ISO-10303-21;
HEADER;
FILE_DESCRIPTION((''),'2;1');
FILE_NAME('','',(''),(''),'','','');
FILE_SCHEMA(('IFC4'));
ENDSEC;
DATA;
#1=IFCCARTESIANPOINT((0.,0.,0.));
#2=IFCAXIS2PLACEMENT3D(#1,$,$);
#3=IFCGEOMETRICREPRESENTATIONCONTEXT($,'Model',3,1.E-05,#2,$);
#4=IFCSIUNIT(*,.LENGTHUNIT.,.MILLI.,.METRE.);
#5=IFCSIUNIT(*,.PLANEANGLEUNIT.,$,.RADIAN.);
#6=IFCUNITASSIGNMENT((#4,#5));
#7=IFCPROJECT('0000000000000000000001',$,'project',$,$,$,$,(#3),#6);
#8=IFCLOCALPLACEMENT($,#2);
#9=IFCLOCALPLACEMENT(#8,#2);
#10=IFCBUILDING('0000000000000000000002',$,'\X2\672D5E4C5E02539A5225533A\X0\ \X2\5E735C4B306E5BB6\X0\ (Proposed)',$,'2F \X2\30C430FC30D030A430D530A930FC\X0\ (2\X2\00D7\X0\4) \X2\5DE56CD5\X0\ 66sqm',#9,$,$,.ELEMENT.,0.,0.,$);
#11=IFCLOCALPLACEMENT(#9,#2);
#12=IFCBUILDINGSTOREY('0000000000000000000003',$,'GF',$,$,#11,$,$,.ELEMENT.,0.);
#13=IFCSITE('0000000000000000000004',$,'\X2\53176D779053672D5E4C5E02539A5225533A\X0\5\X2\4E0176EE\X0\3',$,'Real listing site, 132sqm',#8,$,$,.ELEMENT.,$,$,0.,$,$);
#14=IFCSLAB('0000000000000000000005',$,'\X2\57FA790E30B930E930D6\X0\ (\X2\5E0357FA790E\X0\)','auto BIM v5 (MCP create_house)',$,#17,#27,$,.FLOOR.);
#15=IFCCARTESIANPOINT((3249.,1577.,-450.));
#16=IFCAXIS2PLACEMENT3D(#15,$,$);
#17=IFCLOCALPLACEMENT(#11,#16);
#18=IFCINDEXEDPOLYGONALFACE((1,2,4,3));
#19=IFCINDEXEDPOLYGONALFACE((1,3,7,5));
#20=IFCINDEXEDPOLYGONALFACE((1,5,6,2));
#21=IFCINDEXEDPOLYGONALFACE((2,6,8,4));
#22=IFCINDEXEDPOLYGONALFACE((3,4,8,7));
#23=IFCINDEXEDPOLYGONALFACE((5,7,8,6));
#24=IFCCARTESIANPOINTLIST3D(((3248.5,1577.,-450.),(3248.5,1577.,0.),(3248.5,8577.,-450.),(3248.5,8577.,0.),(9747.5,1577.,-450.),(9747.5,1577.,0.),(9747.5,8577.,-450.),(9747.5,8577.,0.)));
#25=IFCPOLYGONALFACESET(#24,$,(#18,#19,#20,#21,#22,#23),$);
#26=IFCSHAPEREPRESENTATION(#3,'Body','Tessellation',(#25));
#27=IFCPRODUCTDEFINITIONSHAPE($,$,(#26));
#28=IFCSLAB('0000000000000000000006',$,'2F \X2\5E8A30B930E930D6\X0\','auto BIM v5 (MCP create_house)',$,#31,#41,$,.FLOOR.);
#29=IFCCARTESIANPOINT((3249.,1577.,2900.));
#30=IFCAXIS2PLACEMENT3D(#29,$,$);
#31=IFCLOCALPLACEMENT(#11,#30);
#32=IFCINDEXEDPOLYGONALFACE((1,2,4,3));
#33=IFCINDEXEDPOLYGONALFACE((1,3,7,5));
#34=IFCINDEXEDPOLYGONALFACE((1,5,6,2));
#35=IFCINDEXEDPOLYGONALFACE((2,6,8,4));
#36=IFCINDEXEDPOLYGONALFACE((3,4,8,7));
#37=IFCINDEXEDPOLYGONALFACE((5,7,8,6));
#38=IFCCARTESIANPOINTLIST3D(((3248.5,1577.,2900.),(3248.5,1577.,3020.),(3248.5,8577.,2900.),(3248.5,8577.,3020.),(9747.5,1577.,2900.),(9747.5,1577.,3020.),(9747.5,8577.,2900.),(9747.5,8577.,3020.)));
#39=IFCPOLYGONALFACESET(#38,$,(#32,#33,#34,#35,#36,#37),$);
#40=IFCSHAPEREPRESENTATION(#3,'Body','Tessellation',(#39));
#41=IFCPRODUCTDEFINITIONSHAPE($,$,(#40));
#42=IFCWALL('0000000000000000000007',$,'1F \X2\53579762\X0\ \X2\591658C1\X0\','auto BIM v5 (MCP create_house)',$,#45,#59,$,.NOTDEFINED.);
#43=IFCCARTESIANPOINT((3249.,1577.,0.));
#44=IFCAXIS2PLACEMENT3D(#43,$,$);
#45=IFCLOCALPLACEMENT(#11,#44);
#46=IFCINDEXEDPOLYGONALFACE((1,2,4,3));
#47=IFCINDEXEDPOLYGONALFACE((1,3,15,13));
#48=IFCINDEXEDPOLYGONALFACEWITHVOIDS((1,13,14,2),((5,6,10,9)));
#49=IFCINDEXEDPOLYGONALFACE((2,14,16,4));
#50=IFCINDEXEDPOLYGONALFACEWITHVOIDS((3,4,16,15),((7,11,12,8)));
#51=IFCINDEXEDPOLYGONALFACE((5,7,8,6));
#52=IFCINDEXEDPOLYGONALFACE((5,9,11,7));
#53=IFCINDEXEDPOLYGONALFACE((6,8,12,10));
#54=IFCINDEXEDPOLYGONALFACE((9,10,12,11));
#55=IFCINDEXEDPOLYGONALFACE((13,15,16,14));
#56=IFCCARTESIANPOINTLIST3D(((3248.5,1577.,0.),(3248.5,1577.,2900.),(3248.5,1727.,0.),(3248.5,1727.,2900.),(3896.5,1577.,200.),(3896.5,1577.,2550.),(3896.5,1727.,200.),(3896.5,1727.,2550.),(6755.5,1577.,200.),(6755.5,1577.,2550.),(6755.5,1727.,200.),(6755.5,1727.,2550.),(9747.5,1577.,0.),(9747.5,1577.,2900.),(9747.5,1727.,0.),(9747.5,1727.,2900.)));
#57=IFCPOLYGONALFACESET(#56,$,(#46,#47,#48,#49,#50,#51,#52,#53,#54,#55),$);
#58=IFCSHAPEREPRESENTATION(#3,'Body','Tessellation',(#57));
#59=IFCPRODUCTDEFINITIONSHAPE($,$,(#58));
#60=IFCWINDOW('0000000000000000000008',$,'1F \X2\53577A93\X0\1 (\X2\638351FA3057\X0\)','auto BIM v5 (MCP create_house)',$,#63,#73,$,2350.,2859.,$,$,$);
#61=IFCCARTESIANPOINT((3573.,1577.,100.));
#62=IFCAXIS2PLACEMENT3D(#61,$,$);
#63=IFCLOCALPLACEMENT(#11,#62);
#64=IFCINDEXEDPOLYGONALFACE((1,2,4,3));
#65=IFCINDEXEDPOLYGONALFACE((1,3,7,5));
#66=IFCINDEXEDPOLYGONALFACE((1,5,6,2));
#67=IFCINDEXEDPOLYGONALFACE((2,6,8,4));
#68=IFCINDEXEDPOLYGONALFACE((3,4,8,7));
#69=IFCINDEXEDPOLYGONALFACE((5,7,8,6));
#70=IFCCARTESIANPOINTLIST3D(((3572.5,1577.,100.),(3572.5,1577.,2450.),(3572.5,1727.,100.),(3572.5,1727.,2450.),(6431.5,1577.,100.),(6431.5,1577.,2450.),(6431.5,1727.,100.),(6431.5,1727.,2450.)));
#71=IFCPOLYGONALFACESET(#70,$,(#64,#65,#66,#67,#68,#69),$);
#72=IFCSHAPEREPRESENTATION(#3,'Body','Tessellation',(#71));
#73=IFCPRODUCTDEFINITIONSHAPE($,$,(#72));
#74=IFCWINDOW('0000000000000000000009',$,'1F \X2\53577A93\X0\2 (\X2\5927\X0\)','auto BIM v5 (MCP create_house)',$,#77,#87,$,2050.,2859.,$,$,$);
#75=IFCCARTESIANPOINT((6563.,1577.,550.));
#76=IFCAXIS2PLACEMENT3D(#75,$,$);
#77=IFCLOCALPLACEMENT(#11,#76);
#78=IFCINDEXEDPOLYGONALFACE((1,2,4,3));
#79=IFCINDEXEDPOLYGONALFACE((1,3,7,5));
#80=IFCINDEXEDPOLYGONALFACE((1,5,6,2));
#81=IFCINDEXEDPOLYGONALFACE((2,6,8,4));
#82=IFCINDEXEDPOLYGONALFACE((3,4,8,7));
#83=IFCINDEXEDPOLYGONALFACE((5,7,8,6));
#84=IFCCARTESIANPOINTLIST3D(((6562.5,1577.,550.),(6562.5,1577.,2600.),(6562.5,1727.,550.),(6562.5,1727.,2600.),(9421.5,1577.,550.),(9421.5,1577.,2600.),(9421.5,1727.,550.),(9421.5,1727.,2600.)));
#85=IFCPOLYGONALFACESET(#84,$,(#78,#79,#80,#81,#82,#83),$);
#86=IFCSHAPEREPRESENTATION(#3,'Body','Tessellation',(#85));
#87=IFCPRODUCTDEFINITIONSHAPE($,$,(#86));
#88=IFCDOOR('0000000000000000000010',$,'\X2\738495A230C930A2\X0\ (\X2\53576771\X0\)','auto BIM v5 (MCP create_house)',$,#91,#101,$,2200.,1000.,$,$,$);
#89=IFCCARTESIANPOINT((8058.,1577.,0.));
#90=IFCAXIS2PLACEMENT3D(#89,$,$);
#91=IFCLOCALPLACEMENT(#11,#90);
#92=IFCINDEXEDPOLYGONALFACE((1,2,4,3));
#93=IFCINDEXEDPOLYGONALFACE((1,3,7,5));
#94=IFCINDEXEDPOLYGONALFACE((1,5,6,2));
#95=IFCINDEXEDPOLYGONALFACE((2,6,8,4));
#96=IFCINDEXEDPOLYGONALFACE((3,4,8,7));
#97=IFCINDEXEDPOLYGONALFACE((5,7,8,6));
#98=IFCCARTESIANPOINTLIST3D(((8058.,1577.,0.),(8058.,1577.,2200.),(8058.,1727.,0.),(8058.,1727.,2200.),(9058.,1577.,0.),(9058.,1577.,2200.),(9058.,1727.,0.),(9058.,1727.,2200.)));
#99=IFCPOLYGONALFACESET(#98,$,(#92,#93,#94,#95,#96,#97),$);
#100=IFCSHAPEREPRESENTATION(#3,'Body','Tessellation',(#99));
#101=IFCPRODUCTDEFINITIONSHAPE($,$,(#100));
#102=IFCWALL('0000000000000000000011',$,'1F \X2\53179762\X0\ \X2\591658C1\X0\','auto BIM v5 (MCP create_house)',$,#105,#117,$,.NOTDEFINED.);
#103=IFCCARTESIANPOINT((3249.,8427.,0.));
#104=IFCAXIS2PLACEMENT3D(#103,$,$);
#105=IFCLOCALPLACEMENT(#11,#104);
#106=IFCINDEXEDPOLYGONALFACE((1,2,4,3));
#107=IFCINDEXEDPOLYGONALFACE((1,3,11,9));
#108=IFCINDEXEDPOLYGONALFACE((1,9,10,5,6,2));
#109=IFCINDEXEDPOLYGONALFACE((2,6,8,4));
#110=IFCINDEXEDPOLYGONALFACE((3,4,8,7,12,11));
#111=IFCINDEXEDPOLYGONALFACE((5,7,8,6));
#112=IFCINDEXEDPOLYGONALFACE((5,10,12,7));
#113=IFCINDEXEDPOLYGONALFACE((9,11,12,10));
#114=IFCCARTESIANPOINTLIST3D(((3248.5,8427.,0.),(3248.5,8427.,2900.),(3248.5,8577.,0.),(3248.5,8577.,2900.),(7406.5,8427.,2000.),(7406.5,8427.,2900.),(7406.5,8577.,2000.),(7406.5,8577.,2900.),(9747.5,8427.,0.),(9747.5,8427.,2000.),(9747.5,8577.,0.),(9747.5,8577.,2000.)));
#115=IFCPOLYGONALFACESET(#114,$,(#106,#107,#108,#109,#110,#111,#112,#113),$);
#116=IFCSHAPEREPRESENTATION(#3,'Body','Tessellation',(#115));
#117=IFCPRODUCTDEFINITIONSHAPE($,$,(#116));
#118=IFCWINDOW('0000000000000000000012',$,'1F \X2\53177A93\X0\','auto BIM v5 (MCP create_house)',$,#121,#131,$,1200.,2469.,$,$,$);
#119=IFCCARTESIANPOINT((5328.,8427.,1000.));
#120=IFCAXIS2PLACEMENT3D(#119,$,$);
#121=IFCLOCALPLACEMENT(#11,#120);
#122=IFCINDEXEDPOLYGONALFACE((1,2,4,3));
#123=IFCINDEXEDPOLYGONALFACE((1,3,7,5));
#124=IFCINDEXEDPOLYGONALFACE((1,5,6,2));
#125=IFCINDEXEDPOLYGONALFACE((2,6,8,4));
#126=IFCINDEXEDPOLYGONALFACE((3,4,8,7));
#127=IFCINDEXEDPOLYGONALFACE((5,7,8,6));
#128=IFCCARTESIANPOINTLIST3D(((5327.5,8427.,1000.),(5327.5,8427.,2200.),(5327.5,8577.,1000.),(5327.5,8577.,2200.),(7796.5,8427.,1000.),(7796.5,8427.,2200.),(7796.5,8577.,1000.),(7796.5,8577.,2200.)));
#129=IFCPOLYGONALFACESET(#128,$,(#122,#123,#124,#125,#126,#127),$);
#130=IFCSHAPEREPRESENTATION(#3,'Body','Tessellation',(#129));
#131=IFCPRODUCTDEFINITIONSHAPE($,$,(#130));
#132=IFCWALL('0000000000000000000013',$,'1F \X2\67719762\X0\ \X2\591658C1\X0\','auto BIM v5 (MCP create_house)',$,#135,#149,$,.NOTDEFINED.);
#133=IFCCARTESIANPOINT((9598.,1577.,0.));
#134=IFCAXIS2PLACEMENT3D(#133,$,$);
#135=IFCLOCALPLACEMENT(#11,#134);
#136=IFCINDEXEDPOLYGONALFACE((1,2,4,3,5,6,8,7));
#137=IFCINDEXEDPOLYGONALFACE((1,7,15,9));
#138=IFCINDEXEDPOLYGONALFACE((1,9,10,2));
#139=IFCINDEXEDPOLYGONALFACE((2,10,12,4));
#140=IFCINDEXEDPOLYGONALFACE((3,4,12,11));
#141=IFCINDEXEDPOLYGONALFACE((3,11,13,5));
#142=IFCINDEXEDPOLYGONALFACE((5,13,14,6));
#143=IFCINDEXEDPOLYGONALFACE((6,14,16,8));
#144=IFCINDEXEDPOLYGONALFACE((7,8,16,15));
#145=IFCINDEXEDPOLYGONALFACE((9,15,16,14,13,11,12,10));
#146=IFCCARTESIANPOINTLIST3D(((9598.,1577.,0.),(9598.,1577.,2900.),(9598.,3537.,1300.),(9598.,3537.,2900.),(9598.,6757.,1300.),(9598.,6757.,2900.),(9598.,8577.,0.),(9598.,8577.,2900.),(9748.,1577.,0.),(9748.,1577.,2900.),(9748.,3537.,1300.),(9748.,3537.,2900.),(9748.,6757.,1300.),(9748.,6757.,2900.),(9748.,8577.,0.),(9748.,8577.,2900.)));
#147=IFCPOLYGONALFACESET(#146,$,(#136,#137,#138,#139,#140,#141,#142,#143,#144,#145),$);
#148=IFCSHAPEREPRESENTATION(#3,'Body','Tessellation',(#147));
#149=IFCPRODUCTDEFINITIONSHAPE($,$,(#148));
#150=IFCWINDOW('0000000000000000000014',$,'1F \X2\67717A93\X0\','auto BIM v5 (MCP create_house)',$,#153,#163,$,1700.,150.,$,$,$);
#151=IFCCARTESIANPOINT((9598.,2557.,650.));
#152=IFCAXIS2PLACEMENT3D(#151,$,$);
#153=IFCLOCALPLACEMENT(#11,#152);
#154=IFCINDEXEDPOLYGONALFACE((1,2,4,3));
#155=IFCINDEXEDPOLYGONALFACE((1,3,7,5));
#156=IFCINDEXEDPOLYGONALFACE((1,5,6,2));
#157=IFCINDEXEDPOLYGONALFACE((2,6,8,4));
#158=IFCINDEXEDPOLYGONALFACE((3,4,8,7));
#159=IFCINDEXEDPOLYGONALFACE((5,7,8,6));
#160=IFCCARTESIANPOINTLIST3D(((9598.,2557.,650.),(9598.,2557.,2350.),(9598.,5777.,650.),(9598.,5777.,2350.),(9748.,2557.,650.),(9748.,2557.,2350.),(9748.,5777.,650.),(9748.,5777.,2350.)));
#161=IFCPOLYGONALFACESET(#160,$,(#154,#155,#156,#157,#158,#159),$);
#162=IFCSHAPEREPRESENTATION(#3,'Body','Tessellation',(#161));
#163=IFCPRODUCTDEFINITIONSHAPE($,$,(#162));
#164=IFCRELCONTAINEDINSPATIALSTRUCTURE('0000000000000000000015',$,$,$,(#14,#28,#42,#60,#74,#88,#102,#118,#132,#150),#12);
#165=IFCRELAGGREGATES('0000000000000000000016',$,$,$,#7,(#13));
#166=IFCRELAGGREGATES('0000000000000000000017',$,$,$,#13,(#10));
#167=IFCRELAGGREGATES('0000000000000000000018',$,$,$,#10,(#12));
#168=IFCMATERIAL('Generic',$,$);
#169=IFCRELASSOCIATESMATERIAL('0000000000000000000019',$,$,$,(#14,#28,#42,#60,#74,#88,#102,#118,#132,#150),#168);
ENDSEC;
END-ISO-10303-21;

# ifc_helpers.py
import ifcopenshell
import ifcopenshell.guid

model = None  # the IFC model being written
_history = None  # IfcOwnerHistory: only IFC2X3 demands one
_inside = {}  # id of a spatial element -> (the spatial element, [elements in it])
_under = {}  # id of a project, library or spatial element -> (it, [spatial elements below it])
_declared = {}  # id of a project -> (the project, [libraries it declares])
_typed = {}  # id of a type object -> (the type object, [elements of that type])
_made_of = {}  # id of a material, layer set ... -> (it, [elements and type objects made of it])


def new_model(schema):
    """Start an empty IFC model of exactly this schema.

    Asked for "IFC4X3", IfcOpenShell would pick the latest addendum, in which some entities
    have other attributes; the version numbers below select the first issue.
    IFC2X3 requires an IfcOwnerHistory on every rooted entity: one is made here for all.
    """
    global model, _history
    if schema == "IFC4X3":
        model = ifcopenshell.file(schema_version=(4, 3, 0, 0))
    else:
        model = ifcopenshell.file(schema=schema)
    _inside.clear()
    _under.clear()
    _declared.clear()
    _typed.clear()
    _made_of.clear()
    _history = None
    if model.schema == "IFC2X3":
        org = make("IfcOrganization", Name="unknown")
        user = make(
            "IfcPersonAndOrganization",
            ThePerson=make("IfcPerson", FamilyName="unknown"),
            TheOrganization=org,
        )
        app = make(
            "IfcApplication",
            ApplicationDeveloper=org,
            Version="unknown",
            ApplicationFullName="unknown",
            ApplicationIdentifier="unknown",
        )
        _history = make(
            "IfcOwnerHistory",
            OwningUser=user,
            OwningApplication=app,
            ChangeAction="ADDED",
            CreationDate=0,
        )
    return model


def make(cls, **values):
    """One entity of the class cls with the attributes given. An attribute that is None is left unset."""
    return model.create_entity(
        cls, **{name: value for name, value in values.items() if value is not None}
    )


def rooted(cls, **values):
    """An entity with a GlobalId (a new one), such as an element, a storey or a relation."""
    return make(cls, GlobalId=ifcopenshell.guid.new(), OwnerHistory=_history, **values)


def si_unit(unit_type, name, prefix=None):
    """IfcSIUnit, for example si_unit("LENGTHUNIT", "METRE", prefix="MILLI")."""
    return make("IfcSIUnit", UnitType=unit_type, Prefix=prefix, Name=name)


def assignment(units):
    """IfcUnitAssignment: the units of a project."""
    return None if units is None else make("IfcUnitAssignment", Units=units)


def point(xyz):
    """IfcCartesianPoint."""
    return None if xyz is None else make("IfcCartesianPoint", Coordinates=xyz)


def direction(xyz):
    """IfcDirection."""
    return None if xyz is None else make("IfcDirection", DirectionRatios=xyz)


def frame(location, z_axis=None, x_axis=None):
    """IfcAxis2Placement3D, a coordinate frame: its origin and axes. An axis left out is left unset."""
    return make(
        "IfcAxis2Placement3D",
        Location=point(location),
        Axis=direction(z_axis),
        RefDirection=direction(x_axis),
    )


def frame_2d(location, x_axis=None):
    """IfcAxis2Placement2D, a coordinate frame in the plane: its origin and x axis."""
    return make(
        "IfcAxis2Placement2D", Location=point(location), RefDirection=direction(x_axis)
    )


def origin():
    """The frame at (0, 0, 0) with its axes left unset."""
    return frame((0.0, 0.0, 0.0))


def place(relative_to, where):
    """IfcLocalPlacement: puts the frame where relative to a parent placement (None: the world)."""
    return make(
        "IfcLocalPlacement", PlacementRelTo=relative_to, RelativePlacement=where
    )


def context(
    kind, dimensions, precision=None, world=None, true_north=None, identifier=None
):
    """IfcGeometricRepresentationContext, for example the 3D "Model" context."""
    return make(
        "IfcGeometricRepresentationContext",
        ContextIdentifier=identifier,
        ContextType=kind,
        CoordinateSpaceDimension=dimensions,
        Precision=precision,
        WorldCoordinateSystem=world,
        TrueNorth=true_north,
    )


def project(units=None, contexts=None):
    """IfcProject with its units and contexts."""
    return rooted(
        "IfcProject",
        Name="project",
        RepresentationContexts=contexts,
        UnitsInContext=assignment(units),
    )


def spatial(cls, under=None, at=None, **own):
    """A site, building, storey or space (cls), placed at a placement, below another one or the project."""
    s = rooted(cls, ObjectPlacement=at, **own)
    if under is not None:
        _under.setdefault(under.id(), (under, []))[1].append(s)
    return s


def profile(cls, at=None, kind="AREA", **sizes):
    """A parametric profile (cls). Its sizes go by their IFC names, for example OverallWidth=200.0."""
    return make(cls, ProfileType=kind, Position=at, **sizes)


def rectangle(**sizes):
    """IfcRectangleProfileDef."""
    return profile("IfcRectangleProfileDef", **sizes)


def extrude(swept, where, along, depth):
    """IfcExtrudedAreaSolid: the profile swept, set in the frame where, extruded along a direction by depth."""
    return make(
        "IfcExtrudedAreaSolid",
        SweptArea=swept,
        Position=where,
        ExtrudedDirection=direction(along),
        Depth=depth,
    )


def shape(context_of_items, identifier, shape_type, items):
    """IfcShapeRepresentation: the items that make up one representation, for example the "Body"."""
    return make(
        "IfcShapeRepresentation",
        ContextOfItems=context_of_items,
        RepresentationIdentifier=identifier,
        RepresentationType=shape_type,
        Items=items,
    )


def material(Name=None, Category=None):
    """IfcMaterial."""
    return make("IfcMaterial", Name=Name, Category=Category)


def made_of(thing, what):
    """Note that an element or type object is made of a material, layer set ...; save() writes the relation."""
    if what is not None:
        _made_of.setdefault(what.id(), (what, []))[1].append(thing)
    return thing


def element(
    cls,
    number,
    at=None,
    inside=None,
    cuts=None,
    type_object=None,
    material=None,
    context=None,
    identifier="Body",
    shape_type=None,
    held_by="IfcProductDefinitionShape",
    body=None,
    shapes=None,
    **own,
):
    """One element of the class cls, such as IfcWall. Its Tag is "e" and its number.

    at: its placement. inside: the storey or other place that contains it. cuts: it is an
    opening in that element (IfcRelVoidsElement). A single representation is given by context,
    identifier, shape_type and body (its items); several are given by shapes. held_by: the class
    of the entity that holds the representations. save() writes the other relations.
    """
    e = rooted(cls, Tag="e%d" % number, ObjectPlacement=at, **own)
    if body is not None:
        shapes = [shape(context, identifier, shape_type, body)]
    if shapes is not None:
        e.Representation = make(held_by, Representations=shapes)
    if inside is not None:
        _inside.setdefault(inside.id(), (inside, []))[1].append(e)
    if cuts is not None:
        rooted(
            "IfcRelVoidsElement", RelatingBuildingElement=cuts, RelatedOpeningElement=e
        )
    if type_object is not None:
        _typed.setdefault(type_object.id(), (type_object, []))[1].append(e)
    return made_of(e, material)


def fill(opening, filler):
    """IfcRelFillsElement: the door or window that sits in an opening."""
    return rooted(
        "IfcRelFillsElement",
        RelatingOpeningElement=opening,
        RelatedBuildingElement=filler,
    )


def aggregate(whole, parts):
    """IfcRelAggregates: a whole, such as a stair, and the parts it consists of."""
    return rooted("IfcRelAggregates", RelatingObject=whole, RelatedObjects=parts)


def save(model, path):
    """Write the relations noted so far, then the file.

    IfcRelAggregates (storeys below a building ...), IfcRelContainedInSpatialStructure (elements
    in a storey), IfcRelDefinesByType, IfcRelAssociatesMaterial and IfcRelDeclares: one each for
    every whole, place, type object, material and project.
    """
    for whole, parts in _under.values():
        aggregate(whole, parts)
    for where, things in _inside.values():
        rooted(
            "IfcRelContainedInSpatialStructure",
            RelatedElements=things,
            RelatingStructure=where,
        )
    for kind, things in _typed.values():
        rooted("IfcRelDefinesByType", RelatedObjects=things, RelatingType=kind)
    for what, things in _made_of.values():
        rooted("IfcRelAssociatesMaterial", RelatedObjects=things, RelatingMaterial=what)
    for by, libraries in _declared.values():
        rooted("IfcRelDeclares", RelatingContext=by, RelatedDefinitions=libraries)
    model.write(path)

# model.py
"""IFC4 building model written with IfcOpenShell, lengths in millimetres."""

from ifc_helpers import new_model, si_unit, frame, frame_2d, origin, place, context, project, spatial, rectangle, extrude, material, element, fill, save


model = new_model("IFC4")

# Units and contexts
model_context = context("Model", 3, precision=1e-05, world=origin())
ifc_project = project(units=[si_unit("LENGTHUNIT", "METRE", prefix="MILLI"), si_unit("PLANEANGLEUNIT", "RADIAN")], contexts=[model_context])

# Site, building, storey
site_placement = place(None, origin())
site = spatial("IfcSite", under=ifc_project, at=site_placement, Name="北海道札幌市厚別区5丁目3", ObjectType="Real listing site, 132sqm", CompositionType="ELEMENT", RefElevation=0.0)
building_placement = place(site_placement, origin())
building = spatial("IfcBuilding", under=site, at=building_placement, Name="札幌市厚別区 平屋の家 (Proposed)", ObjectType="2F ツーバイフォー (2×4) 工法 66sqm", CompositionType="ELEMENT", ElevationOfRefHeight=0.0, ElevationOfTerrain=0.0)
storey_placement = place(building_placement, origin())
storey = spatial("IfcBuildingStorey", under=building, at=storey_placement, Name="GF", CompositionType="ELEMENT", Elevation=0.0)

# Slabs
ifc_material = material(Name="Generic")
slab_1_placement = place(storey_placement, frame((3249.0, 1577.0, -450.0)))
element("IfcSlab", 1, at=slab_1_placement, inside=storey, material=ifc_material, Name="基礎スラブ (布基礎)", Description="auto BIM v5 (MCP create_house)", PredefinedType="FLOOR", context=model_context, shape_type="SweptSolid", body=[
    extrude(rectangle(XDim=6499.0, YDim=7000.0, at=frame_2d((3249.0, 3500.0))), frame((3249.0, 1577.0, -450.0)), (0.0, 0.0, 1.0), 450.0),
])
slab_2_placement = place(storey_placement, frame((3249.0, 1577.0, 2900.0)))
element("IfcSlab", 2, at=slab_2_placement, inside=storey, material=ifc_material, Name="2F 床スラブ", Description="auto BIM v5 (MCP create_house)", PredefinedType="FLOOR", context=model_context, shape_type="SweptSolid", body=[
    extrude(rectangle(XDim=6499.0, YDim=7000.0, at=frame_2d((3249.0, 3500.0))), frame((3249.0, 1577.0, 2900.0)), (0.0, 0.0, 1.0), 120.0),
])

# Wall, openings, windows, door
wall_1_placement = place(storey_placement, frame((3249.0, 1577.0, 0.0)))
wall_1 = element("IfcWall", 3, at=wall_1_placement, inside=storey, material=ifc_material, Name="1F 南面 外壁", Description="auto BIM v5 (MCP create_house)", PredefinedType="NOTDEFINED", context=model_context, shape_type="SweptSolid", body=[
    extrude(rectangle(XDim=6499.0, YDim=150.0, at=frame_2d((3249.0, 75.0))), frame((3249.0, 1577.0, 0.0)), (0.0, 0.0, 1.0), 2900.0),
])
opening_1_placement = place(storey_placement, frame((3573.0, 1577.0, 100.0)))
opening_1 = element("IfcOpeningElement", 4, at=opening_1_placement, cuts=wall_1, PredefinedType="NOTDEFINED", context=model_context, shape_type="SweptSolid", body=[
    extrude(rectangle(XDim=2859.0, YDim=150.0, at=frame_2d((1429.0, 75.0))), frame((3573.0, 1577.0, 100.0)), (0.0, 0.0, 1.0), 2350.0),
])
opening_2_placement = place(storey_placement, frame((6563.0, 1577.0, 550.0)))
opening_2 = element("IfcOpeningElement", 5, at=opening_2_placement, cuts=wall_1, PredefinedType="NOTDEFINED", context=model_context, shape_type="SweptSolid", body=[
    extrude(rectangle(XDim=2859.0, YDim=150.0, at=frame_2d((1429.0, 75.0))), frame((6563.0, 1577.0, 550.0)), (0.0, 0.0, 1.0), 2050.0),
])
opening_3_placement = place(storey_placement, frame((8058.0, 1577.0, 0.0)))
opening_3 = element("IfcOpeningElement", 6, at=opening_3_placement, cuts=wall_1, PredefinedType="NOTDEFINED", context=model_context, shape_type="SweptSolid", body=[
    extrude(rectangle(XDim=1000.0, YDim=150.0, at=frame_2d((500.0, 75.0))), frame((8058.0, 1577.0, 0.0)), (0.0, 0.0, 1.0), 2200.0),
])
window_1_placement = place(storey_placement, frame((3573.0, 1577.0, 100.0)))
window_1 = element("IfcWindow", 7, at=window_1_placement, inside=storey, material=ifc_material, Name="1F 南窓1 (掃出し)", Description="auto BIM v5 (MCP create_house)", OverallHeight=2350.0, OverallWidth=2859.0, context=model_context, shape_type="SweptSolid", body=[
    extrude(rectangle(XDim=2859.0, YDim=150.0, at=frame_2d((1429.0, 75.0))), frame((3573.0, 1577.0, 100.0)), (0.0, 0.0, 1.0), 2350.0),
])
fill(opening_1, window_1)
window_2_placement = place(storey_placement, frame((6563.0, 1577.0, 550.0)))
window_2 = element("IfcWindow", 8, at=window_2_placement, inside=storey, material=ifc_material, Name="1F 南窓2 (大)", Description="auto BIM v5 (MCP create_house)", OverallHeight=2050.0, OverallWidth=2859.0, context=model_context, shape_type="SweptSolid", body=[
    extrude(rectangle(XDim=2859.0, YDim=150.0, at=frame_2d((1429.0, 75.0))), frame((6563.0, 1577.0, 550.0)), (0.0, 0.0, 1.0), 2050.0),
])
fill(opening_2, window_2)
door_1_placement = place(storey_placement, frame((8058.0, 1577.0, 0.0)))
door_1 = element("IfcDoor", 9, at=door_1_placement, inside=storey, material=ifc_material, Name="玄関ドア (南東)", Description="auto BIM v5 (MCP create_house)", OverallHeight=2200.0, OverallWidth=1000.0, context=model_context, shape_type="SweptSolid", body=[
    extrude(rectangle(XDim=1000.0, YDim=150.0, at=frame_2d((500.0, 75.0))), frame((8058.0, 1577.0, 0.0)), (0.0, 0.0, 1.0), 2200.0),
])
fill(opening_3, door_1)

# Walls, openings, windows
wall_2_placement = place(storey_placement, frame((3249.0, 8427.0, 0.0)))
wall_2 = element("IfcWall", 10, at=wall_2_placement, inside=storey, material=ifc_material, Name="1F 北面 外壁", Description="auto BIM v5 (MCP create_house)", PredefinedType="NOTDEFINED", context=model_context, shape_type="SweptSolid", body=[
    extrude(rectangle(XDim=6499.0, YDim=150.0, at=frame_2d((3249.0, 75.0))), frame((3249.0, 8427.0, 0.0)), (0.0, 0.0, 1.0), 2900.0),
])
opening_4_placement = place(storey_placement, frame((5328.0, 8427.0, 1000.0)))
opening_4 = element("IfcOpeningElement", 11, at=opening_4_placement, cuts=wall_2, PredefinedType="NOTDEFINED", context=model_context, shape_type="SweptSolid", body=[
    extrude(rectangle(XDim=2469.0, YDim=150.0, at=frame_2d((1234.0, 75.0))), frame((5328.0, 8427.0, 1000.0)), (0.0, 0.0, 1.0), 1200.0),
])
window_3_placement = place(storey_placement, frame((5328.0, 8427.0, 1000.0)))
window_3 = element("IfcWindow", 12, at=window_3_placement, inside=storey, material=ifc_material, Name="1F 北窓", Description="auto BIM v5 (MCP create_house)", OverallHeight=1200.0, OverallWidth=2469.0, context=model_context, shape_type="SweptSolid", body=[
    extrude(rectangle(XDim=2469.0, YDim=150.0, at=frame_2d((1234.0, 75.0))), frame((5328.0, 8427.0, 1000.0)), (0.0, 0.0, 1.0), 1200.0),
])
fill(opening_4, window_3)
wall_3_placement = place(storey_placement, frame((9598.0, 1577.0, 0.0)))
wall_3 = element("IfcWall", 13, at=wall_3_placement, inside=storey, material=ifc_material, Name="1F 東面 外壁", Description="auto BIM v5 (MCP create_house)", PredefinedType="NOTDEFINED", context=model_context, shape_type="SweptSolid", body=[
    extrude(rectangle(XDim=150.0, YDim=7000.0, at=frame_2d((75.0, 3500.0))), frame((9598.0, 1577.0, 0.0)), (0.0, 0.0, 1.0), 2900.0),
])
opening_5_placement = place(storey_placement, frame((9598.0, 2557.0, 650.0)))
opening_5 = element("IfcOpeningElement", 14, at=opening_5_placement, cuts=wall_3, PredefinedType="NOTDEFINED", context=model_context, shape_type="SweptSolid", body=[
    extrude(rectangle(XDim=150.0, YDim=3220.0, at=frame_2d((75.0, 1610.0))), frame((9598.0, 2557.0, 650.0)), (0.0, 0.0, 1.0), 1700.0),
])
window_4_placement = place(storey_placement, frame((9598.0, 2557.0, 650.0)))
window_4 = element("IfcWindow", 15, at=window_4_placement, inside=storey, material=ifc_material, Name="1F 東窓", Description="auto BIM v5 (MCP create_house)", OverallHeight=1700.0, OverallWidth=150.0, context=model_context, shape_type="SweptSolid", body=[
    extrude(rectangle(XDim=150.0, YDim=3220.0, at=frame_2d((75.0, 1610.0))), frame((9598.0, 2557.0, 650.0)), (0.0, 0.0, 1.0), 1700.0),
])
fill(opening_5, window_4)

save(model, "model.ifc")
